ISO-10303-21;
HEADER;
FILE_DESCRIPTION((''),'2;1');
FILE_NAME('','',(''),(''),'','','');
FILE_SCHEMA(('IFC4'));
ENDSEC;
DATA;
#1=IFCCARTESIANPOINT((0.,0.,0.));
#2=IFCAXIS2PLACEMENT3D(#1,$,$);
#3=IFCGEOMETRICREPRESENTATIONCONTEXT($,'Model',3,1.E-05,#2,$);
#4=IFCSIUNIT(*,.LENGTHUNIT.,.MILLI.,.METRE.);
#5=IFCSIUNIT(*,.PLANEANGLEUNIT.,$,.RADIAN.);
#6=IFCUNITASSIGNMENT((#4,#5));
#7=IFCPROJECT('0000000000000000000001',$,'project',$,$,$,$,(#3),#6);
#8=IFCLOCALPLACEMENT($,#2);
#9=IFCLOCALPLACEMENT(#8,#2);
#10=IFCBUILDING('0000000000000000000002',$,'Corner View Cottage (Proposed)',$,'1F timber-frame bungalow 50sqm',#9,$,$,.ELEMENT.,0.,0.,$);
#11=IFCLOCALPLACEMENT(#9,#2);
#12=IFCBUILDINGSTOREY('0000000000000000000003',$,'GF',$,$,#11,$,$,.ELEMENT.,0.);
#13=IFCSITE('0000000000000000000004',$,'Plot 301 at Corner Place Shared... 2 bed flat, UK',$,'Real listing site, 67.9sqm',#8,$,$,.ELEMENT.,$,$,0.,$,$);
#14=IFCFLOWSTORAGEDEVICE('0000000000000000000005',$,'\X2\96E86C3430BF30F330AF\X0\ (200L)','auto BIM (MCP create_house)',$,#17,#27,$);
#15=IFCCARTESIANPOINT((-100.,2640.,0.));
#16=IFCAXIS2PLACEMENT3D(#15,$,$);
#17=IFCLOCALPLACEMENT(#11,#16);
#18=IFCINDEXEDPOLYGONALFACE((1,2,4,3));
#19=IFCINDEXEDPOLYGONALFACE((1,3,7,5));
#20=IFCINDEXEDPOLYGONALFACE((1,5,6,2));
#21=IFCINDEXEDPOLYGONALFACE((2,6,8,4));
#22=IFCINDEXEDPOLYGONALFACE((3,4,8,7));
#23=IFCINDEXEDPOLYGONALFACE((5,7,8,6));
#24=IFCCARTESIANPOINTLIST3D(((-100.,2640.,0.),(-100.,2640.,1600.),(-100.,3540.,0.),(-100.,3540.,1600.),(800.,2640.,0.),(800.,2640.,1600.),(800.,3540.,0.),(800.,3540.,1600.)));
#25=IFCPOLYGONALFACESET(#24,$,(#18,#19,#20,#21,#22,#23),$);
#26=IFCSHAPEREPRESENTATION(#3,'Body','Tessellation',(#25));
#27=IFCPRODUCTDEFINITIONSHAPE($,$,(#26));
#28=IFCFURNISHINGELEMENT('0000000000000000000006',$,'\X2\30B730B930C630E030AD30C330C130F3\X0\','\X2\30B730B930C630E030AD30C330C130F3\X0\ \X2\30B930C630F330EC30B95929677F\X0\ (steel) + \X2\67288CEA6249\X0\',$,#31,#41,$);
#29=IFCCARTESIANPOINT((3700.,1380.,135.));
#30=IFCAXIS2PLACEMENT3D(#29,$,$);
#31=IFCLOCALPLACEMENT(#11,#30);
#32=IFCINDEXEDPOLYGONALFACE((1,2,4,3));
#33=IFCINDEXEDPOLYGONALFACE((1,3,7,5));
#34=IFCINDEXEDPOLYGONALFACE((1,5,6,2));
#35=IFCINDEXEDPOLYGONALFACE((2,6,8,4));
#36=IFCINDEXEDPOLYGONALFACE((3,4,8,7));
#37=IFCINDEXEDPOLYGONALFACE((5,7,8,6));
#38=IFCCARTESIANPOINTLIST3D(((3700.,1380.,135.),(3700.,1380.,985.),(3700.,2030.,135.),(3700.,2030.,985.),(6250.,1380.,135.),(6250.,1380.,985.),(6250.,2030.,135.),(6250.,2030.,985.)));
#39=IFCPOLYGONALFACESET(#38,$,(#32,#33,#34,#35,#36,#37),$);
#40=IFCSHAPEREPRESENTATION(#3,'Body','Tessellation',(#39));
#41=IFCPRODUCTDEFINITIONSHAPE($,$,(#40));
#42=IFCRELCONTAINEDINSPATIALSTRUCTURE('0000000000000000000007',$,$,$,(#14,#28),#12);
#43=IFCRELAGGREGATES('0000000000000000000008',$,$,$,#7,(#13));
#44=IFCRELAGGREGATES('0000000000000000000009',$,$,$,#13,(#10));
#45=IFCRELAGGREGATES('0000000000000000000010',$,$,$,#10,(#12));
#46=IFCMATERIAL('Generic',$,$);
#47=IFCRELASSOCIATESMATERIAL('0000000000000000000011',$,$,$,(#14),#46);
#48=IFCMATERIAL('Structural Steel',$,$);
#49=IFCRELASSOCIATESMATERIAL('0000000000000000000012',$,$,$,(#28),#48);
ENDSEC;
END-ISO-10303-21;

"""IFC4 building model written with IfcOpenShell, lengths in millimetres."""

from ifc_helpers import new_model, si_unit, frame, frame_2d, origin, place, context, project, spatial, rectangle, extrude, material, element, save


model = new_model("IFC4")

# Units and contexts
model_context = context("Model", 3, precision=1e-05, world=origin())
ifc_project = project(units=[si_unit("LENGTHUNIT", "METRE", prefix="MILLI"), si_unit("PLANEANGLEUNIT", "RADIAN")], contexts=[model_context])

# Site, building, storey
site_placement = place(None, origin())
site = spatial("IfcSite", under=ifc_project, at=site_placement, Name="Plot 301 at Corner Place Shared... 2 bed flat, UK", ObjectType="Real listing site, 67.9sqm", CompositionType="ELEMENT", RefElevation=0.0)
building_placement = place(site_placement, origin())
building = spatial("IfcBuilding", under=site, at=building_placement, Name="Corner View Cottage (Proposed)", ObjectType="1F timber-frame bungalow 50sqm", CompositionType="ELEMENT", ElevationOfRefHeight=0.0, ElevationOfTerrain=0.0)
storey_placement = place(building_placement, origin())
storey = spatial("IfcBuildingStorey", under=building, at=storey_placement, Name="GF", CompositionType="ELEMENT", Elevation=0.0)

# Shared definitions
ifc_material_1 = material(Name="Generic")

# Flow storage device
flow_storage_device_placement = place(storey_placement, frame((-100.0, 2640.0, 0.0)))
element("IfcFlowStorageDevice", 1, at=flow_storage_device_placement, inside=storey, material=ifc_material_1, Name="雨水タンク (200L)", Description="auto BIM (MCP create_house)", context=model_context, shape_type="SweptSolid", body=[
    extrude(rectangle(XDim=900.0, YDim=900.0, at=frame_2d((450.0, 450.0))), frame((-100.0, 2640.0, 0.0)), (0.0, 0.0, 1.0), 1600.0),
])

# Furnishing element
ifc_material_2 = material(Name="Structural Steel")
furnishing_placement = place(storey_placement, frame((3700.0, 1380.0, 135.0)))
element("IfcFurnishingElement", 2, at=furnishing_placement, inside=storey, material=ifc_material_2, Name="システムキッチン", Description="システムキッチン ステンレス天板 (steel) + 木質扉", context=model_context, shape_type="SweptSolid", body=[
    extrude(rectangle(XDim=2550.0, YDim=650.0, at=frame_2d((1275.0, 325.0))), frame((3700.0, 1380.0, 135.0)), (0.0, 0.0, 1.0), 850.0),
])

save(model, "model.ifc")
